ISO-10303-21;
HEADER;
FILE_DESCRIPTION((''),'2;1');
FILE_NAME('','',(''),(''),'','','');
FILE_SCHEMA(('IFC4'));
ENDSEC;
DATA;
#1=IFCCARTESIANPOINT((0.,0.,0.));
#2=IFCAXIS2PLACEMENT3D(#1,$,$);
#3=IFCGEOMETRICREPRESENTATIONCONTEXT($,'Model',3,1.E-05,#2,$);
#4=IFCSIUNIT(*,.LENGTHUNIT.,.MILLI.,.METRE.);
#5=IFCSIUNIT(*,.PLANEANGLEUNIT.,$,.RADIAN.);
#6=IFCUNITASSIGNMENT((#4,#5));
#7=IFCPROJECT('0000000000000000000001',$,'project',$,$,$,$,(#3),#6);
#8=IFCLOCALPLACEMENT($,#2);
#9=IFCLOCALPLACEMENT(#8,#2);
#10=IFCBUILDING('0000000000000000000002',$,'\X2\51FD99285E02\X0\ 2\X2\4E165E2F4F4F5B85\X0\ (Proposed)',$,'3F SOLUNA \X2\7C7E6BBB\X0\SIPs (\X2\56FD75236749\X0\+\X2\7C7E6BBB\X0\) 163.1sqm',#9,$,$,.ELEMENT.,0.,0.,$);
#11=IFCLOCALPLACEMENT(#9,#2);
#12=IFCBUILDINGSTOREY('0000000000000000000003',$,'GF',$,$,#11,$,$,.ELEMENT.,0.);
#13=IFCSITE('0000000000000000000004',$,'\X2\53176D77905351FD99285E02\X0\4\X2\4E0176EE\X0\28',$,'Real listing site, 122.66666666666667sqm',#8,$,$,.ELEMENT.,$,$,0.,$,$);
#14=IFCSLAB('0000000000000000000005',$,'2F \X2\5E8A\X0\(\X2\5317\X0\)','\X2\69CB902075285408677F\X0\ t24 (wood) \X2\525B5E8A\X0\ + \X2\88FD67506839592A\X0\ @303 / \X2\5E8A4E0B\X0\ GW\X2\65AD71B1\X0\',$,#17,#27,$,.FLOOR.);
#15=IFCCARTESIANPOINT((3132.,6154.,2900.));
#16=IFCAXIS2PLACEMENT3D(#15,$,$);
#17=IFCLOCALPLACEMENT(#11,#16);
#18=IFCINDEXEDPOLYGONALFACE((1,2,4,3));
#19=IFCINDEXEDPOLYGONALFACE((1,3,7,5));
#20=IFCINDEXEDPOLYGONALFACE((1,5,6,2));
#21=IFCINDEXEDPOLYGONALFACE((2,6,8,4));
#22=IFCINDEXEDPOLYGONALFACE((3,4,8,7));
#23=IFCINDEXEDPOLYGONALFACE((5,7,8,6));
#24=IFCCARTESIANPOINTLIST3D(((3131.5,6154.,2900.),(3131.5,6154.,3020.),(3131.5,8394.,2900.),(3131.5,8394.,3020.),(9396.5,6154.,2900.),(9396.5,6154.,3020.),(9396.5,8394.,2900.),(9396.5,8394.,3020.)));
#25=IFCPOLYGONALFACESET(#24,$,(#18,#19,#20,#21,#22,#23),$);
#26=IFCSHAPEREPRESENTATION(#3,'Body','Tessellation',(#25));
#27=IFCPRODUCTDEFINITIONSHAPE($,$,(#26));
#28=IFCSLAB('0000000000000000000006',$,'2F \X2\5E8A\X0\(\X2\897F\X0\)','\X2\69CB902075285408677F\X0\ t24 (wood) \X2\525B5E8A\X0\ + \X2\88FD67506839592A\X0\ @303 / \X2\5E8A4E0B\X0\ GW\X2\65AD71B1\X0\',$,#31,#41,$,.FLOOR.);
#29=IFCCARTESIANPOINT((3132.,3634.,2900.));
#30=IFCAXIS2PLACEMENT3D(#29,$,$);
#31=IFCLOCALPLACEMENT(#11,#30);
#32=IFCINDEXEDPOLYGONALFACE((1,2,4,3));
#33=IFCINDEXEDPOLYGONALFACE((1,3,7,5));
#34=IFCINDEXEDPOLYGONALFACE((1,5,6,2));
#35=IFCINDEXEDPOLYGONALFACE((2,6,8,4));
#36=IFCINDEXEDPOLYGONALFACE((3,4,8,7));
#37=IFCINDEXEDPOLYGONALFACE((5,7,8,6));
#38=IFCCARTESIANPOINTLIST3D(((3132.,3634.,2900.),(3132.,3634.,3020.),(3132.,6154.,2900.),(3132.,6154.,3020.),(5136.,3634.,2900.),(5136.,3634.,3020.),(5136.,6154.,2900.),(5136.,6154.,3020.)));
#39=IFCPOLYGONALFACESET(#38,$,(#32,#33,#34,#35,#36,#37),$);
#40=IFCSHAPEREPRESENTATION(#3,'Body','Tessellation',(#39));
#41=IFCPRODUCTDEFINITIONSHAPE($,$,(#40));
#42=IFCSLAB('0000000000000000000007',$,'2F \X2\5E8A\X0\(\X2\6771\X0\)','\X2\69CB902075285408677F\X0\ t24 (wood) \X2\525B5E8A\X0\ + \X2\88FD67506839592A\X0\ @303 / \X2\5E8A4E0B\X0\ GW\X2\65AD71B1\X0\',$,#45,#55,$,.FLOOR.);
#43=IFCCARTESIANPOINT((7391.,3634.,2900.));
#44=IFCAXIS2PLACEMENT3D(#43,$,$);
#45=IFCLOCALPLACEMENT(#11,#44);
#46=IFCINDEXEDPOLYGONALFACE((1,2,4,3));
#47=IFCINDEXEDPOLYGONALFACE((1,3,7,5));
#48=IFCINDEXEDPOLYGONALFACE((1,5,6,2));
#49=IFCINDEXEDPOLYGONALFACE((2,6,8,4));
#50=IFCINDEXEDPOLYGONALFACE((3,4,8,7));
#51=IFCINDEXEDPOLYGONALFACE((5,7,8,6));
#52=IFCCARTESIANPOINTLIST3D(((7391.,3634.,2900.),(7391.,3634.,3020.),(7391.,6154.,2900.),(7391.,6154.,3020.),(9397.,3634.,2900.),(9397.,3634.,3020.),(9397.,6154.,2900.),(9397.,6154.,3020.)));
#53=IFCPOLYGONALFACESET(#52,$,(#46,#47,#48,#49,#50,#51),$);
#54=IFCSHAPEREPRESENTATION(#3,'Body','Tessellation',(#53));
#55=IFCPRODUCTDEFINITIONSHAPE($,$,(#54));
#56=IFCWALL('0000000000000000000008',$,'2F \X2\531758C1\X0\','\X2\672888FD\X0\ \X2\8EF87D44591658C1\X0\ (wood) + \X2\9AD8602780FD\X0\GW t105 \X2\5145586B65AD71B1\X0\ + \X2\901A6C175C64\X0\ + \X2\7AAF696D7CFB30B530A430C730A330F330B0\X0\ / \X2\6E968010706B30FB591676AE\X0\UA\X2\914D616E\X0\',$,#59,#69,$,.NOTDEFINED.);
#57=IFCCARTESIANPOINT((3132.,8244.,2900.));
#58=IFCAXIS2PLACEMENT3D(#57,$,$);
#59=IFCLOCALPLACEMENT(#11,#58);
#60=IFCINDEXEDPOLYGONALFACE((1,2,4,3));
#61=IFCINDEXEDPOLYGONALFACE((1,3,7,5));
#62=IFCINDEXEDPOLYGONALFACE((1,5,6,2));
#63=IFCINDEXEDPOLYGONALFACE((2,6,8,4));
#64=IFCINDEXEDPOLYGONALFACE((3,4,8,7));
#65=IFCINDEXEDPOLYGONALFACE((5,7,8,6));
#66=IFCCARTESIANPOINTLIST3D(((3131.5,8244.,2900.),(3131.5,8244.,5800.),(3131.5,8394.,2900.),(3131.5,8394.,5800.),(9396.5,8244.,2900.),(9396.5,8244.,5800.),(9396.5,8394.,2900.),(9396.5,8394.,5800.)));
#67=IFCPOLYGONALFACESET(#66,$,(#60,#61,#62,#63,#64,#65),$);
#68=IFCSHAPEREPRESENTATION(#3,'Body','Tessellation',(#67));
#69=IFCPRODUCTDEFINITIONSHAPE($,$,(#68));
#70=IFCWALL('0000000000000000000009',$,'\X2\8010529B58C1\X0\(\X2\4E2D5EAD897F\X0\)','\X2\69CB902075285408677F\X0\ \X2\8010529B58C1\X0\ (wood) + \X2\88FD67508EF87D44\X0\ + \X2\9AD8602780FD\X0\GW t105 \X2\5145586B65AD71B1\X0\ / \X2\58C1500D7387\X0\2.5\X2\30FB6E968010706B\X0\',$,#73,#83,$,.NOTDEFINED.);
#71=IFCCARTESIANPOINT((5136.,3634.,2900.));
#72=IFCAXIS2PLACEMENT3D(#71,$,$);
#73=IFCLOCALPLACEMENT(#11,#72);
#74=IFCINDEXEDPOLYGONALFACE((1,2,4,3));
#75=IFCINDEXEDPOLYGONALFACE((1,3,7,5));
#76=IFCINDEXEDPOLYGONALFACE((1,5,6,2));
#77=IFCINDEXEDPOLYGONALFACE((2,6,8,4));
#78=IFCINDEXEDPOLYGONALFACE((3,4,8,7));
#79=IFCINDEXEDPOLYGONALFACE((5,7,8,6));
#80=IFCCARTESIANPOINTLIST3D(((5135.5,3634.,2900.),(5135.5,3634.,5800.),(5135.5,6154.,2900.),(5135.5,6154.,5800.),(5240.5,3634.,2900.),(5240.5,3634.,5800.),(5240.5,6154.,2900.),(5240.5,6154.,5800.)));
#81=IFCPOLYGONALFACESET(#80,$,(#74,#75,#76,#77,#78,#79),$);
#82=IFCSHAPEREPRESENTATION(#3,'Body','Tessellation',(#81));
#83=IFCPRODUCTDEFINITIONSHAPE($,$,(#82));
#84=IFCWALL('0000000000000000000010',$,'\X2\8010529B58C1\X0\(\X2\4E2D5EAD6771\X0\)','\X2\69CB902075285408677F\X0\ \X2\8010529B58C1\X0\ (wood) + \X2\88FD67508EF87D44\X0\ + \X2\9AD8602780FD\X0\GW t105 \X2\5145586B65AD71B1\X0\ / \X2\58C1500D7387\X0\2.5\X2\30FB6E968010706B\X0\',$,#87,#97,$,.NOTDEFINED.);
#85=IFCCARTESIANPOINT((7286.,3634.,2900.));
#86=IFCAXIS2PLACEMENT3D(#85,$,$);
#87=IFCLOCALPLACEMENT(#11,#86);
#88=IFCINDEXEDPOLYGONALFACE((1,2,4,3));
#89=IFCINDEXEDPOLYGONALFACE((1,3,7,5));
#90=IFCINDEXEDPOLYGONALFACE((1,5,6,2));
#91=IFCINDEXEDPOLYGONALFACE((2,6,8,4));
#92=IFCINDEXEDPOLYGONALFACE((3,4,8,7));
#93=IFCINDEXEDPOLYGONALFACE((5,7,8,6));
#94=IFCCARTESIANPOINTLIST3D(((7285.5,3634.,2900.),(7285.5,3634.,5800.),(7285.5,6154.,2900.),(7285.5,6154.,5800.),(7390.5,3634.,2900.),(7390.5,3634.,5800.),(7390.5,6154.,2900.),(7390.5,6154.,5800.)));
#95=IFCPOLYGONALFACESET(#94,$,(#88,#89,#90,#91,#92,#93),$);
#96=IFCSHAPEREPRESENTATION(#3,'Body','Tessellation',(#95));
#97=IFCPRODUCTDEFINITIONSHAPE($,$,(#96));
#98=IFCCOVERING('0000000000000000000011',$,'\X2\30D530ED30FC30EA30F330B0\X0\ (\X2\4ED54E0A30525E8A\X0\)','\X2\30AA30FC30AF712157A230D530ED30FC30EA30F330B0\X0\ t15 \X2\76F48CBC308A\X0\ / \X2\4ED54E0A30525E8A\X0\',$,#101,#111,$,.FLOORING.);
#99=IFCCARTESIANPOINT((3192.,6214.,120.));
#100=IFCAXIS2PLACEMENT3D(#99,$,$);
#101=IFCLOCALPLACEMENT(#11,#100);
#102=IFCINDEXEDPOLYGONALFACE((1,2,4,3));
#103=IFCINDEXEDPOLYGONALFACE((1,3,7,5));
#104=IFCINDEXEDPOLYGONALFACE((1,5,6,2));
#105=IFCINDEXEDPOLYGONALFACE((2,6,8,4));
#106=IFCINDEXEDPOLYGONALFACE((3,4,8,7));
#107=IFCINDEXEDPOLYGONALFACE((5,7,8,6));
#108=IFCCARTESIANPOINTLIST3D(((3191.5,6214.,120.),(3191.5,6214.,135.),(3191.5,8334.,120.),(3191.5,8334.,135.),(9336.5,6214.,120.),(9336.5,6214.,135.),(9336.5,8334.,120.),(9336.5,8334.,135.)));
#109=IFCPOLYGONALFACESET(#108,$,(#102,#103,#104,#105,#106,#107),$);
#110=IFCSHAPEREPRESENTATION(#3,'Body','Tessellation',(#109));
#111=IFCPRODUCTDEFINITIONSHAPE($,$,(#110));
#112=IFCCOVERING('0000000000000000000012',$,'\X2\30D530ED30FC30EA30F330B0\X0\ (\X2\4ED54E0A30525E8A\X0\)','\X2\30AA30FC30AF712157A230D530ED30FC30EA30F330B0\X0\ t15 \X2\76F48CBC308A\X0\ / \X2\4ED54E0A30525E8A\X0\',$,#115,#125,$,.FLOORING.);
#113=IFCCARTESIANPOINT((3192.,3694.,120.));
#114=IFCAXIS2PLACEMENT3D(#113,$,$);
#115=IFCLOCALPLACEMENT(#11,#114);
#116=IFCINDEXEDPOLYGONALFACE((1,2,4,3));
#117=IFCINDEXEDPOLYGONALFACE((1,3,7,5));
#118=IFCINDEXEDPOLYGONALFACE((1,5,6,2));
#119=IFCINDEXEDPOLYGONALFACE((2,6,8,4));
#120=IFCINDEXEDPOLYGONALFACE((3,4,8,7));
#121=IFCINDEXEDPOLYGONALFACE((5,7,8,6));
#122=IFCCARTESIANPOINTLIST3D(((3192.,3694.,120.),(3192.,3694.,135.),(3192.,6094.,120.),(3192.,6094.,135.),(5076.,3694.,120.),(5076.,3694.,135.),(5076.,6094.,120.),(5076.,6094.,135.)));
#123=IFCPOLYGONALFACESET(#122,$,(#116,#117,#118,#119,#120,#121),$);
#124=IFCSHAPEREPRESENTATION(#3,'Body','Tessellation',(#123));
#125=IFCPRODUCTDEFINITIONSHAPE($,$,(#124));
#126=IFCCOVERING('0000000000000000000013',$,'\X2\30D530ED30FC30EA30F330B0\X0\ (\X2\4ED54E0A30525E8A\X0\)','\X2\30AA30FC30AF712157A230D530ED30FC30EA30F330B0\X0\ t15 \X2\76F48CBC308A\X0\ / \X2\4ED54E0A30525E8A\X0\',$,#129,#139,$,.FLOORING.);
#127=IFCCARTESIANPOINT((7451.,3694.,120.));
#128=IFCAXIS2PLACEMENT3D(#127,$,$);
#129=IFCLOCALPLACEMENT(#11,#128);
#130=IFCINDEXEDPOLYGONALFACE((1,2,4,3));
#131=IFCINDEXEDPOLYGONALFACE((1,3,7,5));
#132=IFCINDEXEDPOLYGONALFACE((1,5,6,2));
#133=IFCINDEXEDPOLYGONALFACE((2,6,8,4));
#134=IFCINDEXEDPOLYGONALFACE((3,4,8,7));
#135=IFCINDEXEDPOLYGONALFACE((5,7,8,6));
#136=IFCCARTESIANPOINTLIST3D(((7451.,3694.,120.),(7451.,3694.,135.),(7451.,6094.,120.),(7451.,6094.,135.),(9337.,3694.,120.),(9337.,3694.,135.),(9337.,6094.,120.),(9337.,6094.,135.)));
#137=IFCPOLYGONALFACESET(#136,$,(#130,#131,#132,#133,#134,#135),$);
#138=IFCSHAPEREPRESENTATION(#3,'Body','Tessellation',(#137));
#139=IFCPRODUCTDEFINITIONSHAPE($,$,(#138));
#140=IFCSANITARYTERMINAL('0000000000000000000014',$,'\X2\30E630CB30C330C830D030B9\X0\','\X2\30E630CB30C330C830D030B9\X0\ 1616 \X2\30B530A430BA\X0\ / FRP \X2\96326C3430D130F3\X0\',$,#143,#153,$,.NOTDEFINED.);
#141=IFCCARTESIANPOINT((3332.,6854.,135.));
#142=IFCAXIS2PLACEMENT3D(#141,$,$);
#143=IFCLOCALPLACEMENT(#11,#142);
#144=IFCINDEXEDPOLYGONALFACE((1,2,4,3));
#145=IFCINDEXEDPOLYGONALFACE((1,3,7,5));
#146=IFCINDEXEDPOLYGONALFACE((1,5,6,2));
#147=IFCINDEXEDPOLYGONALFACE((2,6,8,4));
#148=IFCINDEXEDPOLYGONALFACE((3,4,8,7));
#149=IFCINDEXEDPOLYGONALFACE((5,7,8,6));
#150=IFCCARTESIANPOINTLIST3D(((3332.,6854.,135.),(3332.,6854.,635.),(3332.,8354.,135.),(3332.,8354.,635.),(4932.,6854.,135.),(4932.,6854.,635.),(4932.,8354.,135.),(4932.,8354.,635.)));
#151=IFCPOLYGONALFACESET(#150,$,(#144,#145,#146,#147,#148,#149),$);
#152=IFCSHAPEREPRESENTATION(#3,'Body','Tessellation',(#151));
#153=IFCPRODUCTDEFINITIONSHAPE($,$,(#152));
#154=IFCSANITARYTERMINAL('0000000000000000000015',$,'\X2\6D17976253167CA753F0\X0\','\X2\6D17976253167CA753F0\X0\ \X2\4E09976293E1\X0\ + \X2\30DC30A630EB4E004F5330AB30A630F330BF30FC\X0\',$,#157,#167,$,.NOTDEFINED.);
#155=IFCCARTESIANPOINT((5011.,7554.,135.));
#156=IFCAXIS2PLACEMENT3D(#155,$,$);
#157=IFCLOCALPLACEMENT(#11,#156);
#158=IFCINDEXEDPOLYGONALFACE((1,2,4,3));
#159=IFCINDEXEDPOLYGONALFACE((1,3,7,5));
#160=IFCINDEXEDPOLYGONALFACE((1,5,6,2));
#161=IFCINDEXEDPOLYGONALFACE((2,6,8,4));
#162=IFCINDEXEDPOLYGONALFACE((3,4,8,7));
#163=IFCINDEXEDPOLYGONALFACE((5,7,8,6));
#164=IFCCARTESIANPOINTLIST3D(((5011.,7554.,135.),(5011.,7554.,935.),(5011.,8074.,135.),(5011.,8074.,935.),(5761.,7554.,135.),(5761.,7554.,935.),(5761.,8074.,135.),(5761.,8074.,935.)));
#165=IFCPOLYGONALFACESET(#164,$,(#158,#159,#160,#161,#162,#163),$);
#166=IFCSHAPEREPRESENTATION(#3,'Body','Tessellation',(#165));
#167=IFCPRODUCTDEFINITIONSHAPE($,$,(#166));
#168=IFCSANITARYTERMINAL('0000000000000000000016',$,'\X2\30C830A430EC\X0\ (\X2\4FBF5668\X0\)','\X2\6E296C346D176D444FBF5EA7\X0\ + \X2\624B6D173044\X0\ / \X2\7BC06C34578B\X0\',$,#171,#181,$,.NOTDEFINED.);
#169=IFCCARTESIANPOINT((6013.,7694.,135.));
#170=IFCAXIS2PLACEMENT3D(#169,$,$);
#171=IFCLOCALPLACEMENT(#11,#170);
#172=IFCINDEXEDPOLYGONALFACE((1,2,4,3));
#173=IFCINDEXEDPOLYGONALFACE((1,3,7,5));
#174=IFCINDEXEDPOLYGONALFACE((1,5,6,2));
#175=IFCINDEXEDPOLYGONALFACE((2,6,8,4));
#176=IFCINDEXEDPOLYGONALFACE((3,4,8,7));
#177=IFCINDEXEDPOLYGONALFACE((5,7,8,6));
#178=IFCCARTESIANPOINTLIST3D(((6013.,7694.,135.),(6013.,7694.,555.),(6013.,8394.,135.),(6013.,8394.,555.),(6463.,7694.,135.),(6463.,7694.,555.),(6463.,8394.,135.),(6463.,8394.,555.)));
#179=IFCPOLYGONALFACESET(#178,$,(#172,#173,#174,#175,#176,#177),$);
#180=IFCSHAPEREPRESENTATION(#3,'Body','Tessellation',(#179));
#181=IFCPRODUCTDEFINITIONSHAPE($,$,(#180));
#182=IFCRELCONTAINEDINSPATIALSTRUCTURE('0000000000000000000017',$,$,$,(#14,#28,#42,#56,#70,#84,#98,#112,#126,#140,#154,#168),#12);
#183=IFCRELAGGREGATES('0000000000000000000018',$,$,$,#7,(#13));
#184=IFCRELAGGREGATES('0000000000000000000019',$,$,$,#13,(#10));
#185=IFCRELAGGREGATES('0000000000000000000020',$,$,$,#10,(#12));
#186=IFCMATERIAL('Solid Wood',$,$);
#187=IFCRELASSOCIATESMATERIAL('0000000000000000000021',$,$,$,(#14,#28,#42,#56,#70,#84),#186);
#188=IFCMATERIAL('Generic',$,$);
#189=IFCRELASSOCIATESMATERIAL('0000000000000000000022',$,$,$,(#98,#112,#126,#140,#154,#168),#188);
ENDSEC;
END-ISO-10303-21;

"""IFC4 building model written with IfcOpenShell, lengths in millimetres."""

from ifc_helpers import new_model, si_unit, frame, frame_2d, origin, place, context, project, spatial, rectangle, extrude, material, element, save


model = new_model("IFC4")

# Units and contexts
model_context = context("Model", 3, precision=1e-05, world=origin())
ifc_project = project(units=[si_unit("LENGTHUNIT", "METRE", prefix="MILLI"), si_unit("PLANEANGLEUNIT", "RADIAN")], contexts=[model_context])

# Site, building, storey
site_placement = place(None, origin())
site = spatial("IfcSite", under=ifc_project, at=site_placement, Name="北海道函館市4丁目28", ObjectType="Real listing site, 122.66666666666667sqm", CompositionType="ELEMENT", RefElevation=0.0)
building_placement = place(site_placement, origin())
building = spatial("IfcBuilding", under=site, at=building_placement, Name="函館市 2世帯住宅 (Proposed)", ObjectType="3F SOLUNA 籾殻SIPs (国産杉+籾殻) 163.1sqm", CompositionType="ELEMENT", ElevationOfRefHeight=0.0, ElevationOfTerrain=0.0)
storey_placement = place(building_placement, origin())
storey = spatial("IfcBuildingStorey", under=building, at=storey_placement, Name="GF", CompositionType="ELEMENT", Elevation=0.0)

# Slabs
ifc_material_1 = material(Name="Solid Wood")
slab_1_placement = place(storey_placement, frame((3132.0, 6154.0, 2900.0)))
element("IfcSlab", 1, at=slab_1_placement, inside=storey, material=ifc_material_1, Name="2F 床(北)", Description="構造用合板 t24 (wood) 剛床 + 製材根太 @303 / 床下 GW断熱", PredefinedType="FLOOR", context=model_context, shape_type="SweptSolid", body=[
    extrude(rectangle(XDim=6265.0, YDim=2240.0, at=frame_2d((3132.0, 1120.0))), frame((3132.0, 6154.0, 2900.0)), (0.0, 0.0, 1.0), 120.0),
])
slab_2_placement = place(storey_placement, frame((3132.0, 3634.0, 2900.0)))
element("IfcSlab", 2, at=slab_2_placement, inside=storey, material=ifc_material_1, Name="2F 床(西)", Description="構造用合板 t24 (wood) 剛床 + 製材根太 @303 / 床下 GW断熱", PredefinedType="FLOOR", context=model_context, shape_type="SweptSolid", body=[
    extrude(rectangle(XDim=2004.0, YDim=2520.0, at=frame_2d((1002.0, 1260.0))), frame((3132.0, 3634.0, 2900.0)), (0.0, 0.0, 1.0), 120.0),
])
slab_3_placement = place(storey_placement, frame((7391.0, 3634.0, 2900.0)))
element("IfcSlab", 3, at=slab_3_placement, inside=storey, material=ifc_material_1, Name="2F 床(東)", Description="構造用合板 t24 (wood) 剛床 + 製材根太 @303 / 床下 GW断熱", PredefinedType="FLOOR", context=model_context, shape_type="SweptSolid", body=[
    extrude(rectangle(XDim=2006.0, YDim=2520.0, at=frame_2d((1003.0, 1260.0))), frame((7391.0, 3634.0, 2900.0)), (0.0, 0.0, 1.0), 120.0),
])

# Wall
wall_1_placement = place(storey_placement, frame((3132.0, 8244.0, 2900.0)))
element("IfcWall", 4, at=wall_1_placement, inside=storey, material=ifc_material_1, Name="2F 北壁", Description="木製 軸組外壁 (wood) + 高性能GW t105 充填断熱 + 通気層 + 窯業系サイディング / 準耐火・外皮UA配慮", PredefinedType="NOTDEFINED", context=model_context, shape_type="SweptSolid", body=[
    extrude(rectangle(XDim=6265.0, YDim=150.0, at=frame_2d((3132.0, 75.0))), frame((3132.0, 8244.0, 2900.0)), (0.0, 0.0, 1.0), 2900.0),
])

# Walls
wall_2_placement = place(storey_placement, frame((5136.0, 3634.0, 2900.0)))
element("IfcWall", 5, at=wall_2_placement, inside=storey, material=ifc_material_1, Name="耐力壁(中庭西)", Description="構造用合板 耐力壁 (wood) + 製材軸組 + 高性能GW t105 充填断熱 / 壁倍率2.5・準耐火", PredefinedType="NOTDEFINED", context=model_context, shape_type="SweptSolid", body=[
    extrude(rectangle(XDim=105.0, YDim=2520.0, at=frame_2d((52.0, 1260.0))), frame((5136.0, 3634.0, 2900.0)), (0.0, 0.0, 1.0), 2900.0),
])
wall_3_placement = place(storey_placement, frame((7286.0, 3634.0, 2900.0)))
element("IfcWall", 6, at=wall_3_placement, inside=storey, material=ifc_material_1, Name="耐力壁(中庭東)", Description="構造用合板 耐力壁 (wood) + 製材軸組 + 高性能GW t105 充填断熱 / 壁倍率2.5・準耐火", PredefinedType="NOTDEFINED", context=model_context, shape_type="SweptSolid", body=[
    extrude(rectangle(XDim=105.0, YDim=2520.0, at=frame_2d((52.0, 1260.0))), frame((7286.0, 3634.0, 2900.0)), (0.0, 0.0, 1.0), 2900.0),
])

# Coverings
ifc_material_2 = material(Name="Generic")
covering_1_placement = place(storey_placement, frame((3192.0, 6214.0, 120.0)))
element("IfcCovering", 7, at=covering_1_placement, inside=storey, material=ifc_material_2, Name="フローリング (仕上げ床)", Description="オーク無垢フローリング t15 直貼り / 仕上げ床", PredefinedType="FLOORING", context=model_context, shape_type="SweptSolid", body=[
    extrude(rectangle(XDim=6145.0, YDim=2120.0, at=frame_2d((3072.0, 1060.0))), frame((3192.0, 6214.0, 120.0)), (0.0, 0.0, 1.0), 15.0),
])
covering_2_placement = place(storey_placement, frame((3192.0, 3694.0, 120.0)))
element("IfcCovering", 8, at=covering_2_placement, inside=storey, material=ifc_material_2, Name="フローリング (仕上げ床)", Description="オーク無垢フローリング t15 直貼り / 仕上げ床", PredefinedType="FLOORING", context=model_context, shape_type="SweptSolid", body=[
    extrude(rectangle(XDim=1884.0, YDim=2400.0, at=frame_2d((942.0, 1200.0))), frame((3192.0, 3694.0, 120.0)), (0.0, 0.0, 1.0), 15.0),
])
covering_3_placement = place(storey_placement, frame((7451.0, 3694.0, 120.0)))
element("IfcCovering", 9, at=covering_3_placement, inside=storey, material=ifc_material_2, Name="フローリング (仕上げ床)", Description="オーク無垢フローリング t15 直貼り / 仕上げ床", PredefinedType="FLOORING", context=model_context, shape_type="SweptSolid", body=[
    extrude(rectangle(XDim=1886.0, YDim=2400.0, at=frame_2d((943.0, 1200.0))), frame((7451.0, 3694.0, 120.0)), (0.0, 0.0, 1.0), 15.0),
])

# Sanitary terminals
sanitary_terminal_1_placement = place(storey_placement, frame((3332.0, 6854.0, 135.0)))
element("IfcSanitaryTerminal", 10, at=sanitary_terminal_1_placement, inside=storey, material=ifc_material_2, Name="ユニットバス", Description="ユニットバス 1616 サイズ / FRP 防水パン", PredefinedType="NOTDEFINED", context=model_context, shape_type="SweptSolid", body=[
    extrude(rectangle(XDim=1600.0, YDim=1500.0, at=frame_2d((800.0, 750.0))), frame((3332.0, 6854.0, 135.0)), (0.0, 0.0, 1.0), 500.0),
])
sanitary_terminal_2_placement = place(storey_placement, frame((5011.0, 7554.0, 135.0)))
element("IfcSanitaryTerminal", 11, at=sanitary_terminal_2_placement, inside=storey, material=ifc_material_2, Name="洗面化粧台", Description="洗面化粧台 三面鏡 + ボウル一体カウンター", PredefinedType="NOTDEFINED", context=model_context, shape_type="SweptSolid", body=[
    extrude(rectangle(XDim=750.0, YDim=520.0, at=frame_2d((375.0, 260.0))), frame((5011.0, 7554.0, 135.0)), (0.0, 0.0, 1.0), 800.0),
])
sanitary_terminal_3_placement = place(storey_placement, frame((6013.0, 7694.0, 135.0)))
element("IfcSanitaryTerminal", 12, at=sanitary_terminal_3_placement, inside=storey, material=ifc_material_2, Name="トイレ (便器)", Description="温水洗浄便座 + 手洗い / 節水型", PredefinedType="NOTDEFINED", context=model_context, shape_type="SweptSolid", body=[
    extrude(rectangle(XDim=450.0, YDim=700.0, at=frame_2d((225.0, 350.0))), frame((6013.0, 7694.0, 135.0)), (0.0, 0.0, 1.0), 420.0),
])

save(model, "model.ifc")
